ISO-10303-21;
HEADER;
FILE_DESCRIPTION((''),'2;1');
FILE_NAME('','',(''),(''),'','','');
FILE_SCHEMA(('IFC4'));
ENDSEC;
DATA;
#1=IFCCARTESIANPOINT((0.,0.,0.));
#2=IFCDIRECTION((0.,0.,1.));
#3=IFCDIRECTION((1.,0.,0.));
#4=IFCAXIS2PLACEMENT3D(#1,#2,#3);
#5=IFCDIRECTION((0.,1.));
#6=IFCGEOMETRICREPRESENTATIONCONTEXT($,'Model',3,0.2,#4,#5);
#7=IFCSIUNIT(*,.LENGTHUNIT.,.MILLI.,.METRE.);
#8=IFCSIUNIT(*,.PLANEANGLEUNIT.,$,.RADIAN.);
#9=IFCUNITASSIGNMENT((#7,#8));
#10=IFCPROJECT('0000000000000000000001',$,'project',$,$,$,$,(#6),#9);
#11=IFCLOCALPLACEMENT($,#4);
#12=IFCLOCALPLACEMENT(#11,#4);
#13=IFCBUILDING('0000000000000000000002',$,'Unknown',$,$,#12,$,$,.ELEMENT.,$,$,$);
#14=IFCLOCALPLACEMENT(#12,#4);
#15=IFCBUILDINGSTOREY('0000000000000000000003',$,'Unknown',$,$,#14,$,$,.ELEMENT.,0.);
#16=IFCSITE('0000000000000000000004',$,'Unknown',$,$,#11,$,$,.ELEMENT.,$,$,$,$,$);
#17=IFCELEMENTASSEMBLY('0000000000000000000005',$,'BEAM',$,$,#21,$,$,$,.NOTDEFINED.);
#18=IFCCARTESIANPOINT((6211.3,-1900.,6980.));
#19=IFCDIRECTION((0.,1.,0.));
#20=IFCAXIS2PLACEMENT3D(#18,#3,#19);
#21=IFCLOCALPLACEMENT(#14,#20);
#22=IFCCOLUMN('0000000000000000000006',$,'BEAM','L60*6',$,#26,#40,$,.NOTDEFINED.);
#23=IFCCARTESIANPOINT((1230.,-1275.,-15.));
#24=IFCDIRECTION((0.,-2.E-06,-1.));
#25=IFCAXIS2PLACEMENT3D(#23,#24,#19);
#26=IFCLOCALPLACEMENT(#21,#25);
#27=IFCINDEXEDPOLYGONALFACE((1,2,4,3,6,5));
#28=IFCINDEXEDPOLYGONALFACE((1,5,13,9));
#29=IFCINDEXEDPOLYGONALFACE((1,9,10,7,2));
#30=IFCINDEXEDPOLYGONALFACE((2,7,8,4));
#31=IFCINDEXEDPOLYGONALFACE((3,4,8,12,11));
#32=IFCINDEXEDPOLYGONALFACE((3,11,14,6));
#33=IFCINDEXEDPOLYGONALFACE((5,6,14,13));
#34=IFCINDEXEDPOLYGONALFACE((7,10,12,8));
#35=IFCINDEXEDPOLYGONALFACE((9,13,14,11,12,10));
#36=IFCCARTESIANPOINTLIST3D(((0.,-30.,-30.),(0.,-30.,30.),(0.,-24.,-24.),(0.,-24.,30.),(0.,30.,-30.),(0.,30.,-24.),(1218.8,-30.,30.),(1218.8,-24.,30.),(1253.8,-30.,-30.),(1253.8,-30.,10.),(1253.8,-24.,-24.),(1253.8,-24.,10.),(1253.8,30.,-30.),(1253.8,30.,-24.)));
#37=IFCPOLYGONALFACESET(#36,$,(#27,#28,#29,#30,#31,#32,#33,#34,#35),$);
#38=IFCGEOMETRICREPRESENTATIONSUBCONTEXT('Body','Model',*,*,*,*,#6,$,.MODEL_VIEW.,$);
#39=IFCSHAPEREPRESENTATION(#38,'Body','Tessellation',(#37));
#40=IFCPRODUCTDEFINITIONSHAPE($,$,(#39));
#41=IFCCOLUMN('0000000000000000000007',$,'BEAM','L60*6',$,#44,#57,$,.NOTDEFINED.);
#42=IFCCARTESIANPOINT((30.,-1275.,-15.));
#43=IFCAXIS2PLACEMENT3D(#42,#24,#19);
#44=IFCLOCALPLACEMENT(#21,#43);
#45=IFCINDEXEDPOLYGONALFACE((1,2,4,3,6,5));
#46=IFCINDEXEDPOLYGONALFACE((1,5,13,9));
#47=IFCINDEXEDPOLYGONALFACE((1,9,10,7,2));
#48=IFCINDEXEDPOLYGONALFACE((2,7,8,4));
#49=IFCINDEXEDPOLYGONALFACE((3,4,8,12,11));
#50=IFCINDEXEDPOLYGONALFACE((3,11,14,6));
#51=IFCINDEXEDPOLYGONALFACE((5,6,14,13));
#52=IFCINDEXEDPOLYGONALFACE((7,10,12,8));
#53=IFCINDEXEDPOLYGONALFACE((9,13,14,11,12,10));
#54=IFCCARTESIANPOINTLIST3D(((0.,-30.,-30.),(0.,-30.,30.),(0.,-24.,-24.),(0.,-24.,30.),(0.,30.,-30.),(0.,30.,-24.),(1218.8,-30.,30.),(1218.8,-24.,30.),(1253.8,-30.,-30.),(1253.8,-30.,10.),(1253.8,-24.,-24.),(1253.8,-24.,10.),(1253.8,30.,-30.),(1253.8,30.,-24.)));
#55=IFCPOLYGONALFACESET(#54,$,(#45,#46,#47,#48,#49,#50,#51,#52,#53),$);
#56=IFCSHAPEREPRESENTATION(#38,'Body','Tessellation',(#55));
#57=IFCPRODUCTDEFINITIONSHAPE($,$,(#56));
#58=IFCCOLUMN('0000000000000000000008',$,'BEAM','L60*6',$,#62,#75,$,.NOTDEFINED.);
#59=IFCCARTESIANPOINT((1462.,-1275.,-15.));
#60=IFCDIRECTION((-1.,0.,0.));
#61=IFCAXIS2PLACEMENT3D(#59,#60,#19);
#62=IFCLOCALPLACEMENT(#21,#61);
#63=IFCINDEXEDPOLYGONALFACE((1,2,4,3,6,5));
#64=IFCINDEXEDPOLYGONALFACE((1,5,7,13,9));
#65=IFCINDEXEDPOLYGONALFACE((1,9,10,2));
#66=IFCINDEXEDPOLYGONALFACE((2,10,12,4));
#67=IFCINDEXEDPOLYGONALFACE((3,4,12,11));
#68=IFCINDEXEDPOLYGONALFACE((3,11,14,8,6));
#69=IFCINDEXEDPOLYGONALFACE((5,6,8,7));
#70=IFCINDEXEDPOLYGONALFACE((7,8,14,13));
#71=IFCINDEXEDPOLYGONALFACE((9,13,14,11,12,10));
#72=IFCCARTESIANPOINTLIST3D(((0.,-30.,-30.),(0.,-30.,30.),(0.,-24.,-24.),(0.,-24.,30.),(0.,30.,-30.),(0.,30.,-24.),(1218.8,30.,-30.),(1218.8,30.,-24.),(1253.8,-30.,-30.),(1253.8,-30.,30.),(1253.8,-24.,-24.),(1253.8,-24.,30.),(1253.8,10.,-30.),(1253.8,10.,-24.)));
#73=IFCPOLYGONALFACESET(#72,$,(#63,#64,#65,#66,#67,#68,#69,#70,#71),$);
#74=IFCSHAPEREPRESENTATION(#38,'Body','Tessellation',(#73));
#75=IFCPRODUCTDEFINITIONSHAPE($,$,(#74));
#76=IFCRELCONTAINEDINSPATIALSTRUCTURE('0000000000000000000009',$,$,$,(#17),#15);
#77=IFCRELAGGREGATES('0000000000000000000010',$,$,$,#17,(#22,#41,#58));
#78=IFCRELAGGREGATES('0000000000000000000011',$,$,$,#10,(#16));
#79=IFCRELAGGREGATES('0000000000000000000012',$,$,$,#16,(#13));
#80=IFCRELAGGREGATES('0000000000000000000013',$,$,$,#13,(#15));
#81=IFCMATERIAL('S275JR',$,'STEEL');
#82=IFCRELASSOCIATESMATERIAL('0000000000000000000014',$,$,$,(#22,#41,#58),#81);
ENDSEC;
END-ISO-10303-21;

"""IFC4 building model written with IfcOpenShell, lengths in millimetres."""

from ifc_helpers import new_model, si_unit, direction, frame, origin_with_axes, place, context, subcontext, project, spatial, line, indexed_curve, outline, extrude, material, element, aggregate, save


model = new_model("IFC4")

# Units and contexts
model_context = context("Model", 3, precision=0.2, world=origin_with_axes(), true_north=direction((0.0, 1.0)))
body_context = subcontext(model_context, "Body", "Model", "MODEL_VIEW")
ifc_project = project(units=[si_unit("LENGTHUNIT", "METRE", prefix="MILLI"), si_unit("PLANEANGLEUNIT", "RADIAN")], contexts=[model_context])

# Site, building, storey
site_placement = place(None, origin_with_axes())
site = spatial("IfcSite", under=ifc_project, at=site_placement, Name="Unknown", CompositionType="ELEMENT")
building_placement = place(site_placement, origin_with_axes())
building = spatial("IfcBuilding", under=site, at=building_placement, Name="Unknown", CompositionType="ELEMENT")
storey_placement = place(building_placement, origin_with_axes())
storey = spatial("IfcBuildingStorey", under=building, at=storey_placement, Name="Unknown", CompositionType="ELEMENT", Elevation=0.0)

# Element assembly, columns, voiding features
assembly_1_placement = place(storey_placement, frame((6211.3, -1900.0, 6980.0), z_axis=(1.0, 0.0, 0.0), x_axis=(0.0, 1.0, 0.0)))
assembly_1 = element("IfcElementAssembly", 1, at=assembly_1_placement, inside=storey, Name="BEAM", PredefinedType="NOTDEFINED")
ifc_material_1 = material(Name="S275JR", Category="STEEL")
column_1_placement = place(assembly_1_placement, frame((1230.0, -1275.0, -15.0), z_axis=(0.0, -0.000002, -1.0), x_axis=(0.0, 1.0, 0.0)))
column_1 = element("IfcColumn", 2, at=column_1_placement, material=ifc_material_1, Name="BEAM", Description="L60*6", PredefinedType="NOTDEFINED", context=body_context, shape_type="SolidModel", body=[
    extrude(outline(indexed_curve([(-30.0, -30.0), (30.0, -30.0), (30.0, -24.0), (-24.0, -24.0), (-24.0, 30.0), (-30.0, 30.0)], segments=[line(1, 2, 3, 4, 5, 6, 1)])), frame((0.0, 0.0, 0.0), z_axis=(-1.0, 0.0, 0.0), x_axis=(0.0, 0.0, 1.0)), (0.0, -0.000002, -1.0), 1253.8),
])
voiding_feature_1_placement = place(column_1_placement, frame((1253.8, 0.0, 10.0), z_axis=(0.0, -1.0, 0.000002), x_axis=(0.0, 0.0, 1.0)))
element("IfcVoidingFeature", 3, at=voiding_feature_1_placement, cuts=column_1, Name="CUTPART", PredefinedType="HOLE", context=body_context, shape_type="SolidModel", body=[
    extrude(outline(indexed_curve([(0.0, 0.0), (20.0, 0.0), (20.0, 35.0)], segments=[line(1, 2, 3, 1)])), frame((0.0, 0.0, 33.0), z_axis=(0.0, 0.0, 1.0), x_axis=(1.0, 0.0, 0.0)), (0.0, -0.000002, -1.0), 66.0),
])
column_2_placement = place(assembly_1_placement, frame((30.0, -1275.0, -15.0), z_axis=(0.0, -0.000002, -1.0), x_axis=(0.0, 1.0, 0.0)))
column_2 = element("IfcColumn", 4, at=column_2_placement, material=ifc_material_1, Name="BEAM", Description="L60*6", PredefinedType="NOTDEFINED", context=body_context, shape_type="SolidModel", body=[
    extrude(outline(indexed_curve([(-30.0, -30.0), (30.0, -30.0), (30.0, -24.0), (-24.0, -24.0), (-24.0, 30.0), (-30.0, 30.0)], segments=[line(1, 2, 3, 4, 5, 6, 1)])), frame((0.0, 0.0, 0.0), z_axis=(-1.0, 0.0, 0.0), x_axis=(0.0, 0.0, 1.0)), (0.0, -0.000002, -1.0), 1253.8),
])
voiding_feature_2_placement = place(column_2_placement, frame((1253.8, 0.0, 10.0), z_axis=(0.0, -1.0, 0.000002), x_axis=(0.0, 0.0, 1.0)))
element("IfcVoidingFeature", 5, at=voiding_feature_2_placement, cuts=column_2, Name="CUTPART", PredefinedType="HOLE", context=body_context, shape_type="SolidModel", body=[
    extrude(outline(indexed_curve([(0.0, 0.0), (20.0, 0.0), (20.0, 35.0)], segments=[line(1, 2, 3, 1)])), frame((0.0, 0.0, 33.0), z_axis=(0.0, 0.0, 1.0), x_axis=(1.0, 0.0, 0.0)), (0.0, -0.000002, -1.0), 66.0),
])
column_3_placement = place(assembly_1_placement, frame((1462.0, -1275.0, -15.0), z_axis=(-1.0, 0.0, 0.0), x_axis=(0.0, 1.0, 0.0)))
column_3 = element("IfcColumn", 6, at=column_3_placement, material=ifc_material_1, Name="BEAM", Description="L60*6", PredefinedType="NOTDEFINED", context=body_context, shape_type="SolidModel", body=[
    extrude(outline(indexed_curve([(-30.0, -30.0), (30.0, -30.0), (30.0, -24.0), (-24.0, -24.0), (-24.0, 30.0), (-30.0, 30.0)], segments=[line(1, 2, 3, 4, 5, 6, 1)])), frame((0.0, 0.0, 0.0), z_axis=(-1.0, 0.0, 0.0), x_axis=(0.0, 0.0, 1.0)), (0.0, -0.000002, -1.0), 1253.8),
])
voiding_feature_3_placement = place(column_3_placement, frame((1253.8, 10.0, 0.0), z_axis=(0.0, 0.0, 1.0), x_axis=(0.0, 1.0, 0.0)))
element("IfcVoidingFeature", 7, at=voiding_feature_3_placement, cuts=column_3, Name="CUTPART", PredefinedType="HOLE", context=body_context, shape_type="SolidModel", body=[
    extrude(outline(indexed_curve([(0.0, 0.0), (20.0, 0.0), (20.0, 35.0)], segments=[line(1, 2, 3, 1)])), frame((0.0, 0.0, 33.0), z_axis=(0.0, 0.0, 1.0), x_axis=(1.0, 0.0, 0.0)), (0.0, -0.000002, -1.0), 66.0),
])
aggregate(assembly_1, [column_1, column_2, column_3])

save(model, "model.ifc")
